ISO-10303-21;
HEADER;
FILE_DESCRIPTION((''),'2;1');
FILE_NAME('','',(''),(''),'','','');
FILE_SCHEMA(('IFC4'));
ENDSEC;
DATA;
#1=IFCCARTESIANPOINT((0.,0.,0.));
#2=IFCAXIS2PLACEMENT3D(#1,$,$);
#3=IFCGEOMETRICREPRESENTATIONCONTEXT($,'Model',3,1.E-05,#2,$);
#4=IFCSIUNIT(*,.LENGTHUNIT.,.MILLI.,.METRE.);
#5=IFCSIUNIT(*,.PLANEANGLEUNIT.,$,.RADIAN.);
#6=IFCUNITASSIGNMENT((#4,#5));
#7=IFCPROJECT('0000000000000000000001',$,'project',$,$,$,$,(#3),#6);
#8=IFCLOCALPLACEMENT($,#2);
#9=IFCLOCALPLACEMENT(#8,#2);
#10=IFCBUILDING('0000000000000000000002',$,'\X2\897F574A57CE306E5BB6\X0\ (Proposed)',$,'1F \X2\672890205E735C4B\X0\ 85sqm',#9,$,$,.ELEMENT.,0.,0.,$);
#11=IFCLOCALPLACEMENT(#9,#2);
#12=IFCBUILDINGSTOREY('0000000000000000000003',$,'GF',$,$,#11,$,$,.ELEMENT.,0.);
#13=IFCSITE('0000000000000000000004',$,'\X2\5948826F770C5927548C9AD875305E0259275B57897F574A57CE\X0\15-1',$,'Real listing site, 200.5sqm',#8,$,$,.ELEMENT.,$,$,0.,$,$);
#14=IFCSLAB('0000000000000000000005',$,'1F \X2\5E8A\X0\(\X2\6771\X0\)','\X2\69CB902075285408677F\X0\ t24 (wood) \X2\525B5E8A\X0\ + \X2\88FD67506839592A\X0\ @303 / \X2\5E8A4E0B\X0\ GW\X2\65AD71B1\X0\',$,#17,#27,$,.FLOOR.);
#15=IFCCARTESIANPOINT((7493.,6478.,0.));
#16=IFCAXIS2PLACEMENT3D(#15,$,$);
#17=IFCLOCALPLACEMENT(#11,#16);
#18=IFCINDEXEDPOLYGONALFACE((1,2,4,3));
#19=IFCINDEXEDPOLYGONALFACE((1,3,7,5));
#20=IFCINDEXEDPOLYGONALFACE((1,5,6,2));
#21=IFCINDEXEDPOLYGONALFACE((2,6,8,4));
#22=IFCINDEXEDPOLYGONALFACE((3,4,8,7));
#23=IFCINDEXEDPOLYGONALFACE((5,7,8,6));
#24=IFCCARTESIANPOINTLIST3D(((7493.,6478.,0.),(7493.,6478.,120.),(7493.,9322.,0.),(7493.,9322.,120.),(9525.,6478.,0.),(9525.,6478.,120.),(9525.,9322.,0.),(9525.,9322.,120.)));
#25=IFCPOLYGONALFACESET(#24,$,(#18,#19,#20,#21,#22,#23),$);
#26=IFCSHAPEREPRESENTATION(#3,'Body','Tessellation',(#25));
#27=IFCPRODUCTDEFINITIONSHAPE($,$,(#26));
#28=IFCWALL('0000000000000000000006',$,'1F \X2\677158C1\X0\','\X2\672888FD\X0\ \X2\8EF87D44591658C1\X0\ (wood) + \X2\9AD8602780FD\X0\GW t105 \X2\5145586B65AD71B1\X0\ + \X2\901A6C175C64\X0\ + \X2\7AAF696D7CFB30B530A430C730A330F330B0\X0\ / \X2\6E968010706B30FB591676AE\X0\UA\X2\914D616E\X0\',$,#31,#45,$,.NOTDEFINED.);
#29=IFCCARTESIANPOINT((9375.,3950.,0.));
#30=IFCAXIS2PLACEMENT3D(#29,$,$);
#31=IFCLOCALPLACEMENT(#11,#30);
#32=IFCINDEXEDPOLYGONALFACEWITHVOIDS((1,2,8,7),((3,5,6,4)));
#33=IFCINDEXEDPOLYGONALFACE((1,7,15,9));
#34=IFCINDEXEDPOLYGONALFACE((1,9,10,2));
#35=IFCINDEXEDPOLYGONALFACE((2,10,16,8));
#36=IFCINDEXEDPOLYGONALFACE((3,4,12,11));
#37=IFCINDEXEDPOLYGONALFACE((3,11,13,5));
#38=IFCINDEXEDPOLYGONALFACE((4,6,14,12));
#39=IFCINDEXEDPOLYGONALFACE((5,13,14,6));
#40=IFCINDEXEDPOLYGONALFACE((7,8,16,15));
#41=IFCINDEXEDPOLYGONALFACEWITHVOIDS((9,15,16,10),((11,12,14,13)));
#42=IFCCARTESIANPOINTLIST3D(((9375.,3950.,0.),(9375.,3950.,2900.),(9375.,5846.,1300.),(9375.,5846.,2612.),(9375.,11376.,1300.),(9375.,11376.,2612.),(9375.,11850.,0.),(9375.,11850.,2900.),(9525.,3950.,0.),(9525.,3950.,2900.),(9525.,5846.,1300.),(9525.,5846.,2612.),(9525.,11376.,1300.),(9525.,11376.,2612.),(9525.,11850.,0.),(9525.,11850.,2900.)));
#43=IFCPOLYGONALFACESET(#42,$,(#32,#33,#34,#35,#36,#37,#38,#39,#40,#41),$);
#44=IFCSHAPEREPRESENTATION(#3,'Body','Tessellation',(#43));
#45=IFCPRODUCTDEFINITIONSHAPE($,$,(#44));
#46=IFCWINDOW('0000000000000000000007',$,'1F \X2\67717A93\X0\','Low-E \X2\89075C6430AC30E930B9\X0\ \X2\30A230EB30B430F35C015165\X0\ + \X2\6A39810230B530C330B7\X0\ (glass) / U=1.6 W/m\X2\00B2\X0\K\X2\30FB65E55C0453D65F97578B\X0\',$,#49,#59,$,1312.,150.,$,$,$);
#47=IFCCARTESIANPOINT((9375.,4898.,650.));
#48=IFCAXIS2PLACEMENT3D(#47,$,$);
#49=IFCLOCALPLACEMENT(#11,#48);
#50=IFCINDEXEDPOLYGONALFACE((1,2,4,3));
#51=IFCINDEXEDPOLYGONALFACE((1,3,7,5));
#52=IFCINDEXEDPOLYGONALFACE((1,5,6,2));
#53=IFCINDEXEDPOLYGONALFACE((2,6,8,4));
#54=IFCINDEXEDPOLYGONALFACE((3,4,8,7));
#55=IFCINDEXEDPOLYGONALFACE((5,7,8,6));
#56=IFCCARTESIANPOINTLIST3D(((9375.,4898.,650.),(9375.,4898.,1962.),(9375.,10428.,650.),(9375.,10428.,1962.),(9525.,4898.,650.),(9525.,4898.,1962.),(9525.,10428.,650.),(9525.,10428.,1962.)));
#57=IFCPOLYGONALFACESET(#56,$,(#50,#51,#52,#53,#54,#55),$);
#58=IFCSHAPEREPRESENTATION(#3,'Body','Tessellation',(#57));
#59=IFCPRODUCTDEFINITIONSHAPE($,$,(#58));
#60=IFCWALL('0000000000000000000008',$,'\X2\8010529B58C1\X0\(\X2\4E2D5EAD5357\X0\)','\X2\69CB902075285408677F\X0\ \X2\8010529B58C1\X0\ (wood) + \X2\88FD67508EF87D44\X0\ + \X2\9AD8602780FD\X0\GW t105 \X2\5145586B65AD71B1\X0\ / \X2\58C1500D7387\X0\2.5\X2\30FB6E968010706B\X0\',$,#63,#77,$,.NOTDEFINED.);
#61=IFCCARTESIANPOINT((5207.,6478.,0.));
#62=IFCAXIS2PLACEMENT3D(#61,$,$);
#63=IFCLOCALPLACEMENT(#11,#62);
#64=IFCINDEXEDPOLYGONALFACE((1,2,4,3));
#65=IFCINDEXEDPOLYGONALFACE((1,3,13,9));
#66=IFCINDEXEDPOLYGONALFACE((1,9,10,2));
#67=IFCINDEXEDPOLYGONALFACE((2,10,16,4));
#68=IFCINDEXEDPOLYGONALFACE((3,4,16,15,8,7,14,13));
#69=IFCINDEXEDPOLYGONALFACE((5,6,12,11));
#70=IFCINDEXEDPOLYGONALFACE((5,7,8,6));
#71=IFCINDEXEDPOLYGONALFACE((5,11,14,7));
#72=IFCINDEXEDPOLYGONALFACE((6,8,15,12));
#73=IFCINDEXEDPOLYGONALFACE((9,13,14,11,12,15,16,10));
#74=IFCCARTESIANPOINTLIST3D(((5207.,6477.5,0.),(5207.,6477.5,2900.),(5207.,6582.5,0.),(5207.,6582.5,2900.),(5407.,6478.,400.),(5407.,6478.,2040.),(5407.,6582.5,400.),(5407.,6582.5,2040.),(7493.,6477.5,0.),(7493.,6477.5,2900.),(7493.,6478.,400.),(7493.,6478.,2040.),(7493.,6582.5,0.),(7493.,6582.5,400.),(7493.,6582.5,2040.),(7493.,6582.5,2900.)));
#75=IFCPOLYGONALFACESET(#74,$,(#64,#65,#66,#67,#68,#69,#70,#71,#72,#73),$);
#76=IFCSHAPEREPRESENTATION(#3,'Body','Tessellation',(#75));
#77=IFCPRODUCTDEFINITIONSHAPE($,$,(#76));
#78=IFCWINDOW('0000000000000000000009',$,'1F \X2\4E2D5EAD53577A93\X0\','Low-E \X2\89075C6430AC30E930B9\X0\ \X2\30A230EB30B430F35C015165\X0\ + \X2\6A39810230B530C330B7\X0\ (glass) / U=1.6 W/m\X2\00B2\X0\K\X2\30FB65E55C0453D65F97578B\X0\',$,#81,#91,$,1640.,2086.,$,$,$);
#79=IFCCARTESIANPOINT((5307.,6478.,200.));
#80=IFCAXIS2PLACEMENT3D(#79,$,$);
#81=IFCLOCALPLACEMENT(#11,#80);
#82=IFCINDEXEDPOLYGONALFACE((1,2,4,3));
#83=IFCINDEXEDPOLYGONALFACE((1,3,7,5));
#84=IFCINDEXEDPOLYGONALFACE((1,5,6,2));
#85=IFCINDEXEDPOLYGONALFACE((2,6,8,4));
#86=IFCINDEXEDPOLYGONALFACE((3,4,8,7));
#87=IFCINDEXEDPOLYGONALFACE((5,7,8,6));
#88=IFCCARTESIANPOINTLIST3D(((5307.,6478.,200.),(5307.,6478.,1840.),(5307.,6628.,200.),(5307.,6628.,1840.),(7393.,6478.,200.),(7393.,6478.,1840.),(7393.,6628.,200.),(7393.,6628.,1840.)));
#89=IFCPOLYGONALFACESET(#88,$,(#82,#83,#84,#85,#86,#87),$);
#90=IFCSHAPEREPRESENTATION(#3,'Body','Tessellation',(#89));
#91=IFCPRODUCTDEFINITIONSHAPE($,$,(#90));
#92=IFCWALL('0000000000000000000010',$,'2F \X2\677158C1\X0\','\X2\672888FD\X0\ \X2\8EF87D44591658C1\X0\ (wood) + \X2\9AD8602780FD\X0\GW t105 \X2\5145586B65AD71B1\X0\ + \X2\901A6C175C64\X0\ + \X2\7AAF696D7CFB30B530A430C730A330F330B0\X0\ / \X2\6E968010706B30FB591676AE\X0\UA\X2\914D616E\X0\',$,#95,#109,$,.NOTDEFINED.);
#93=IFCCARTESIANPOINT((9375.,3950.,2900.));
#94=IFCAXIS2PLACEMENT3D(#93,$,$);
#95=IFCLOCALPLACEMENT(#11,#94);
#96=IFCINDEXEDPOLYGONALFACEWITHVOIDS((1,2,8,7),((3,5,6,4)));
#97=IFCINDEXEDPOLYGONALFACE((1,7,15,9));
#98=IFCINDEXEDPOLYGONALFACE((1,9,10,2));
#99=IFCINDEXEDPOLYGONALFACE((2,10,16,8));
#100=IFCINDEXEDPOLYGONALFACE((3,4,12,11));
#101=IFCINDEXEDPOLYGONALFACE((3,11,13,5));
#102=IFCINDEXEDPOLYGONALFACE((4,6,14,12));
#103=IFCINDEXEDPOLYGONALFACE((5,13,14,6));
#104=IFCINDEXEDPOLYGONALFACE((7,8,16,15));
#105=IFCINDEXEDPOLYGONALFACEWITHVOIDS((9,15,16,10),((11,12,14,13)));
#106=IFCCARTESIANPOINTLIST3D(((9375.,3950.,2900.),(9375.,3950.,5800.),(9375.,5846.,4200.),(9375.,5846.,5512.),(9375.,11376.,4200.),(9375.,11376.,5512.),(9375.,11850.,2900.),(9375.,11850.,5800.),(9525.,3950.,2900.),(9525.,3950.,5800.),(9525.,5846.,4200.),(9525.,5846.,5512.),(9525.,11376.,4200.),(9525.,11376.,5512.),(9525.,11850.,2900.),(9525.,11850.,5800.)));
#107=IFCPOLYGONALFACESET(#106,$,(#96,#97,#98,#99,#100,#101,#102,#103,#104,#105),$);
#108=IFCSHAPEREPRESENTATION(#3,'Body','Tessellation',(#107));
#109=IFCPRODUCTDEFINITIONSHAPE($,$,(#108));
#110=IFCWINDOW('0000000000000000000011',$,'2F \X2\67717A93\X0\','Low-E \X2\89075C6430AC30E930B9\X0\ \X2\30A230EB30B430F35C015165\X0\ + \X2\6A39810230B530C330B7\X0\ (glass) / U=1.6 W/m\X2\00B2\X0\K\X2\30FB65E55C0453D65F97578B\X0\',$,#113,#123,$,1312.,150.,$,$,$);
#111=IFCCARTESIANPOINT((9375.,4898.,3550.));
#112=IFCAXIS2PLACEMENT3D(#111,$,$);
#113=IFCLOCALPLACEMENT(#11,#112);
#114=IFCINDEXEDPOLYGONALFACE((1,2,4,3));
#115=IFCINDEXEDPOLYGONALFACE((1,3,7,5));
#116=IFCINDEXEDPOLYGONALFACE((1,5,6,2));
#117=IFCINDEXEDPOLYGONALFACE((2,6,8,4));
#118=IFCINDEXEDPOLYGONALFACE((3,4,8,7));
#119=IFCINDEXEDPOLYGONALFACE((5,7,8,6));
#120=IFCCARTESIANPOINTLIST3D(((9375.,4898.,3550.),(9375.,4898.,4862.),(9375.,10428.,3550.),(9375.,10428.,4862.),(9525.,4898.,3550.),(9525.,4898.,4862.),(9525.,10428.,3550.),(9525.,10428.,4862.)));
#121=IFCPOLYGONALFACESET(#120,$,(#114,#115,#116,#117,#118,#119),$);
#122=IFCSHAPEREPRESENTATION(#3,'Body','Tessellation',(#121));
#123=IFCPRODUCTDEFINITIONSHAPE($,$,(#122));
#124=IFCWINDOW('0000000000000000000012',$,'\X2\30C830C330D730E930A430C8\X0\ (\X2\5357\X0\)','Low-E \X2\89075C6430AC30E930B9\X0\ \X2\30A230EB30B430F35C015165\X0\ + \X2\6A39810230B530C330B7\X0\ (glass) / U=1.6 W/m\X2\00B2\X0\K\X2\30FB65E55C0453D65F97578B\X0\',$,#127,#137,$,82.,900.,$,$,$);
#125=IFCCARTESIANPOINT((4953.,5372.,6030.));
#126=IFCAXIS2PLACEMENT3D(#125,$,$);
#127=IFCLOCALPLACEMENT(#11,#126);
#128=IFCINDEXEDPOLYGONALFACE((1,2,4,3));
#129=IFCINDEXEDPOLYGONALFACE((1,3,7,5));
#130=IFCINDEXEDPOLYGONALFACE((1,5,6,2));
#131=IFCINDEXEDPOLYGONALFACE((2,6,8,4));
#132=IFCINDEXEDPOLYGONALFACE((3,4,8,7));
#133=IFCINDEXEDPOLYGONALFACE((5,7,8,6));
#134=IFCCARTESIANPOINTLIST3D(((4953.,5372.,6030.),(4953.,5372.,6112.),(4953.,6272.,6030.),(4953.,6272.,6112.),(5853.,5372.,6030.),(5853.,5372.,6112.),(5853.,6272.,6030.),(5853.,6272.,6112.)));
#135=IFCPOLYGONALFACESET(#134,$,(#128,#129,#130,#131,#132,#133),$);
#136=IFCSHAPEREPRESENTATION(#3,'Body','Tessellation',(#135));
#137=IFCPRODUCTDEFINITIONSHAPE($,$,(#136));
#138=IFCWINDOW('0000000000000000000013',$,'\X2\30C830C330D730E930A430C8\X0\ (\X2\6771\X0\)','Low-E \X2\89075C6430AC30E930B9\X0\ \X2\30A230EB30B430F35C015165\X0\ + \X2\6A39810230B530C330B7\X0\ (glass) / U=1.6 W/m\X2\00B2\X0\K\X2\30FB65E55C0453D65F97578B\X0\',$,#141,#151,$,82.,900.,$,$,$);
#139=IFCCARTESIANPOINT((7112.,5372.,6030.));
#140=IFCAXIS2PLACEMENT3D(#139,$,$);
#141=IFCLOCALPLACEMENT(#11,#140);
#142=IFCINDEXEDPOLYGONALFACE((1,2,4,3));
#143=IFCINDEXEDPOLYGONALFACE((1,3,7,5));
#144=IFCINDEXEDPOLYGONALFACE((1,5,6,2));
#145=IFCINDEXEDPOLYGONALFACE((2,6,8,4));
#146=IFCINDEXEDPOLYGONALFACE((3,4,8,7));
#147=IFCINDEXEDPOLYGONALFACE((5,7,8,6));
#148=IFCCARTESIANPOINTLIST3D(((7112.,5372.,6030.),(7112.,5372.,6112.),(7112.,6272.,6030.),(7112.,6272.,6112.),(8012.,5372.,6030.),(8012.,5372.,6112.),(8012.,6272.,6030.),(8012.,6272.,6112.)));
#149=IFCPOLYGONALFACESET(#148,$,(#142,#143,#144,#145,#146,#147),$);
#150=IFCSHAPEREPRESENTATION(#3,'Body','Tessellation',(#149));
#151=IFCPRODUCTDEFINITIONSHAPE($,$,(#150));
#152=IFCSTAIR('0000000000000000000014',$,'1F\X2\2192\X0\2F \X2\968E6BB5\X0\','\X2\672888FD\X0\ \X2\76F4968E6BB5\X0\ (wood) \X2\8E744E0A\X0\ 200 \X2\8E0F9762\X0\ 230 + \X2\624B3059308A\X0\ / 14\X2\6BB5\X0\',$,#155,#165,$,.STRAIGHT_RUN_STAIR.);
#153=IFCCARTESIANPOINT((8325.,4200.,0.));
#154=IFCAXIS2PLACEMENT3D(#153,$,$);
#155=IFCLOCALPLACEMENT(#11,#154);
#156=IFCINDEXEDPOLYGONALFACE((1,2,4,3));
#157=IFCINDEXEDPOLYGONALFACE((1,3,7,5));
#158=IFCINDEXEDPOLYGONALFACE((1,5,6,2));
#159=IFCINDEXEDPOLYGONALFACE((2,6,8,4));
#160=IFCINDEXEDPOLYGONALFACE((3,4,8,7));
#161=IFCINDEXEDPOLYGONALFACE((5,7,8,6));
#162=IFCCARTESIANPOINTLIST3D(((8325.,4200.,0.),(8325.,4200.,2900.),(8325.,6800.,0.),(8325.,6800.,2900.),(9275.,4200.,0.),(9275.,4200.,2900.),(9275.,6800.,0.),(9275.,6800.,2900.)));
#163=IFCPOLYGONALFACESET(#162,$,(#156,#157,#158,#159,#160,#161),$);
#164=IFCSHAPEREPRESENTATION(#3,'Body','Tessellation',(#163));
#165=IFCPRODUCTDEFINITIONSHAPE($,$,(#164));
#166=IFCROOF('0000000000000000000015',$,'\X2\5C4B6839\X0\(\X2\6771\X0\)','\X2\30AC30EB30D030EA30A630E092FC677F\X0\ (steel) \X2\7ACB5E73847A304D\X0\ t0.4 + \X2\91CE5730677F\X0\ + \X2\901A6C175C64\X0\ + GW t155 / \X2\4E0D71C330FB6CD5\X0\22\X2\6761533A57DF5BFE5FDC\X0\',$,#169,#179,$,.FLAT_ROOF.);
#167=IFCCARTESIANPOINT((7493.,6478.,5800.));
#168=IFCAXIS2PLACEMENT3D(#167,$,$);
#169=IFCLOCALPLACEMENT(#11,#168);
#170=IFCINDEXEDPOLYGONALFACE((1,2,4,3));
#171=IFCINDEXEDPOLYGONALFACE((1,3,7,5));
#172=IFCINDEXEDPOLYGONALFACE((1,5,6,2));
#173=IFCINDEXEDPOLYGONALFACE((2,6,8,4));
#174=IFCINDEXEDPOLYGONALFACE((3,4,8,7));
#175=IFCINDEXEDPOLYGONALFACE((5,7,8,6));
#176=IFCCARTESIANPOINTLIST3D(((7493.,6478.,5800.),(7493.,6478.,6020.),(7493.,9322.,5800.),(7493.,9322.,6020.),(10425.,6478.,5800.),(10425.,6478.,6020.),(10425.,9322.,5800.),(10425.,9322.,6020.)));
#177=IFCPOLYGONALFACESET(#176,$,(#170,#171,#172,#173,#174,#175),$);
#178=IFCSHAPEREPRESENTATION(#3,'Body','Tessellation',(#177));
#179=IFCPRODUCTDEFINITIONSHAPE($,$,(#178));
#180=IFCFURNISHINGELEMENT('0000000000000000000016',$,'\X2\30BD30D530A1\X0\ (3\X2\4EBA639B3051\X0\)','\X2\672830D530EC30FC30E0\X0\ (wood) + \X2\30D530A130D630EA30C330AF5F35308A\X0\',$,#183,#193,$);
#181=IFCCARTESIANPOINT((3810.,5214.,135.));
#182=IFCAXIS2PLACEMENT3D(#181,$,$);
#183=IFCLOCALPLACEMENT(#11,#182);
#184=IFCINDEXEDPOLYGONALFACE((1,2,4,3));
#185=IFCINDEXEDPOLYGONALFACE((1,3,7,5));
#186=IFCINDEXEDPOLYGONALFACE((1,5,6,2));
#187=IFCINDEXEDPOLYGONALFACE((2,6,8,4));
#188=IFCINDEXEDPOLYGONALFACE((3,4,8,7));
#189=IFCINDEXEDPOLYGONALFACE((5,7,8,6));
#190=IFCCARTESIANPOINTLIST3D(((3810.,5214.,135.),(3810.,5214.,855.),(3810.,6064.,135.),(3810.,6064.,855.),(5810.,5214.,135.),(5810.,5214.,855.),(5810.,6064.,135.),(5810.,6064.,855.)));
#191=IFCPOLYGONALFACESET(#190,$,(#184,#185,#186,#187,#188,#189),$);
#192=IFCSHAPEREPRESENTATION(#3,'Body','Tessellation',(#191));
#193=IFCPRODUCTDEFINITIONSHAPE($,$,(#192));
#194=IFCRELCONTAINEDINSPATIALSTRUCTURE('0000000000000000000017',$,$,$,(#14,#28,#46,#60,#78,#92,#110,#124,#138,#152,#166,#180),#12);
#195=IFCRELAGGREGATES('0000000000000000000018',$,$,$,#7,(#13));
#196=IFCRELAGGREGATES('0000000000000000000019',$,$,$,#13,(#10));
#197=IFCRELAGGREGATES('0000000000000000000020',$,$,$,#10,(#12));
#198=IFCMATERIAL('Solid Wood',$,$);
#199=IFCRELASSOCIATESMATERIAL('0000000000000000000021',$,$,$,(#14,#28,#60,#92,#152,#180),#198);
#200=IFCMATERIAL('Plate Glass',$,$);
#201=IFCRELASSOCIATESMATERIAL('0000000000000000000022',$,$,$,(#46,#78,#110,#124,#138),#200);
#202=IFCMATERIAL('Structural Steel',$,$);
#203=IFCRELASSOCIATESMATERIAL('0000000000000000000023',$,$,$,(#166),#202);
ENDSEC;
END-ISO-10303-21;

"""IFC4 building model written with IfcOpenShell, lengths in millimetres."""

from ifc_helpers import new_model, si_unit, frame, frame_2d, origin, place, context, project, spatial, rectangle, extrude, material, element, fill, save


model = new_model("IFC4")

# Units and contexts
model_context = context("Model", 3, precision=1e-05, world=origin())
ifc_project = project(units=[si_unit("LENGTHUNIT", "METRE", prefix="MILLI"), si_unit("PLANEANGLEUNIT", "RADIAN")], contexts=[model_context])

# Site, building, storey
site_placement = place(None, origin())
site = spatial("IfcSite", under=ifc_project, at=site_placement, Name="奈良県大和高田市大字西坊城15-1", ObjectType="Real listing site, 200.5sqm", CompositionType="ELEMENT", RefElevation=0.0)
building_placement = place(site_placement, origin())
building = spatial("IfcBuilding", under=site, at=building_placement, Name="西坊城の家 (Proposed)", ObjectType="1F 木造平屋 85sqm", CompositionType="ELEMENT", ElevationOfRefHeight=0.0, ElevationOfTerrain=0.0)
storey_placement = place(building_placement, origin())
storey = spatial("IfcBuildingStorey", under=building, at=storey_placement, Name="GF", CompositionType="ELEMENT", Elevation=0.0)

# Slab
ifc_material_1 = material(Name="Solid Wood")
slab_placement = place(storey_placement, frame((7493.0, 6478.0, 0.0)))
element("IfcSlab", 1, at=slab_placement, inside=storey, material=ifc_material_1, Name="1F 床(東)", Description="構造用合板 t24 (wood) 剛床 + 製材根太 @303 / 床下 GW断熱", PredefinedType="FLOOR", context=model_context, shape_type="SweptSolid", body=[
    extrude(rectangle(XDim=2032.0, YDim=2844.0, at=frame_2d((1016.0, 1422.0))), frame((7493.0, 6478.0, 0.0)), (0.0, 0.0, 1.0), 120.0),
])

# Walls, openings, windows
wall_1_placement = place(storey_placement, frame((9375.0, 3950.0, 0.0)))
wall_1 = element("IfcWall", 2, at=wall_1_placement, inside=storey, material=ifc_material_1, Name="1F 東壁", Description="木製 軸組外壁 (wood) + 高性能GW t105 充填断熱 + 通気層 + 窯業系サイディング / 準耐火・外皮UA配慮", PredefinedType="NOTDEFINED", context=model_context, shape_type="SweptSolid", body=[
    extrude(rectangle(XDim=150.0, YDim=7900.0, at=frame_2d((75.0, 3950.0))), frame((9375.0, 3950.0, 0.0)), (0.0, 0.0, 1.0), 2900.0),
])
opening_1_placement = place(storey_placement, frame((9375.0, 4898.0, 650.0)))
opening_1 = element("IfcOpeningElement", 3, at=opening_1_placement, cuts=wall_1, PredefinedType="NOTDEFINED", context=model_context, shape_type="SweptSolid", body=[
    extrude(rectangle(XDim=150.0, YDim=5530.0, at=frame_2d((75.0, 2765.0))), frame((9375.0, 4898.0, 650.0)), (0.0, 0.0, 1.0), 1312.0),
])
ifc_material_2 = material(Name="Plate Glass")
window_1_placement = place(storey_placement, frame((9375.0, 4898.0, 650.0)))
window_1 = element("IfcWindow", 4, at=window_1_placement, inside=storey, material=ifc_material_2, Name="1F 東窓", Description="Low-E 複層ガラス アルゴン封入 + 樹脂サッシ (glass) / U=1.6 W/m²K・日射取得型", OverallHeight=1312.0, OverallWidth=150.0, context=model_context, shape_type="SweptSolid", body=[
    extrude(rectangle(XDim=150.0, YDim=5530.0, at=frame_2d((75.0, 2765.0))), frame((9375.0, 4898.0, 650.0)), (0.0, 0.0, 1.0), 1312.0),
])
fill(opening_1, window_1)
wall_2_placement = place(storey_placement, frame((5207.0, 6478.0, 0.0)))
wall_2 = element("IfcWall", 5, at=wall_2_placement, inside=storey, material=ifc_material_1, Name="耐力壁(中庭南)", Description="構造用合板 耐力壁 (wood) + 製材軸組 + 高性能GW t105 充填断熱 / 壁倍率2.5・準耐火", PredefinedType="NOTDEFINED", context=model_context, shape_type="SweptSolid", body=[
    extrude(rectangle(XDim=2286.0, YDim=105.0, at=frame_2d((1143.0, 52.0))), frame((5207.0, 6478.0, 0.0)), (0.0, 0.0, 1.0), 2900.0),
])
opening_2_placement = place(storey_placement, frame((5307.0, 6478.0, 200.0)))
opening_2 = element("IfcOpeningElement", 6, at=opening_2_placement, cuts=wall_2, PredefinedType="NOTDEFINED", context=model_context, shape_type="SweptSolid", body=[
    extrude(rectangle(XDim=2086.0, YDim=150.0, at=frame_2d((1043.0, 75.0))), frame((5307.0, 6478.0, 200.0)), (0.0, 0.0, 1.0), 1640.0),
])
window_2_placement = place(storey_placement, frame((5307.0, 6478.0, 200.0)))
window_2 = element("IfcWindow", 7, at=window_2_placement, inside=storey, material=ifc_material_2, Name="1F 中庭南窓", Description="Low-E 複層ガラス アルゴン封入 + 樹脂サッシ (glass) / U=1.6 W/m²K・日射取得型", OverallHeight=1640.0, OverallWidth=2086.0, context=model_context, shape_type="SweptSolid", body=[
    extrude(rectangle(XDim=2086.0, YDim=150.0, at=frame_2d((1043.0, 75.0))), frame((5307.0, 6478.0, 200.0)), (0.0, 0.0, 1.0), 1640.0),
])
fill(opening_2, window_2)

# Wall, opening, window
wall_3_placement = place(storey_placement, frame((9375.0, 3950.0, 2900.0)))
wall_3 = element("IfcWall", 8, at=wall_3_placement, inside=storey, material=ifc_material_1, Name="2F 東壁", Description="木製 軸組外壁 (wood) + 高性能GW t105 充填断熱 + 通気層 + 窯業系サイディング / 準耐火・外皮UA配慮", PredefinedType="NOTDEFINED", context=model_context, shape_type="SweptSolid", body=[
    extrude(rectangle(XDim=150.0, YDim=7900.0, at=frame_2d((75.0, 3950.0))), frame((9375.0, 3950.0, 2900.0)), (0.0, 0.0, 1.0), 2900.0),
])
opening_3_placement = place(storey_placement, frame((9375.0, 4898.0, 3550.0)))
opening_3 = element("IfcOpeningElement", 9, at=opening_3_placement, cuts=wall_3, PredefinedType="NOTDEFINED", context=model_context, shape_type="SweptSolid", body=[
    extrude(rectangle(XDim=150.0, YDim=5530.0, at=frame_2d((75.0, 2765.0))), frame((9375.0, 4898.0, 3550.0)), (0.0, 0.0, 1.0), 1312.0),
])
window_3_placement = place(storey_placement, frame((9375.0, 4898.0, 3550.0)))
window_3 = element("IfcWindow", 10, at=window_3_placement, inside=storey, material=ifc_material_2, Name="2F 東窓", Description="Low-E 複層ガラス アルゴン封入 + 樹脂サッシ (glass) / U=1.6 W/m²K・日射取得型", OverallHeight=1312.0, OverallWidth=150.0, context=model_context, shape_type="SweptSolid", body=[
    extrude(rectangle(XDim=150.0, YDim=5530.0, at=frame_2d((75.0, 2765.0))), frame((9375.0, 4898.0, 3550.0)), (0.0, 0.0, 1.0), 1312.0),
])
fill(opening_3, window_3)

# Windows
window_4_placement = place(storey_placement, frame((4953.0, 5372.0, 6030.0)))
element("IfcWindow", 11, at=window_4_placement, inside=storey, material=ifc_material_2, Name="トップライト (南)", Description="Low-E 複層ガラス アルゴン封入 + 樹脂サッシ (glass) / U=1.6 W/m²K・日射取得型", OverallHeight=82.0, OverallWidth=900.0, context=model_context, shape_type="SweptSolid", body=[
    extrude(rectangle(XDim=900.0, YDim=900.0, at=frame_2d((450.0, 450.0))), frame((4953.0, 5372.0, 6030.0)), (0.0, 0.0, 1.0), 82.0),
])
window_5_placement = place(storey_placement, frame((7112.0, 5372.0, 6030.0)))
element("IfcWindow", 12, at=window_5_placement, inside=storey, material=ifc_material_2, Name="トップライト (東)", Description="Low-E 複層ガラス アルゴン封入 + 樹脂サッシ (glass) / U=1.6 W/m²K・日射取得型", OverallHeight=82.0, OverallWidth=900.0, context=model_context, shape_type="SweptSolid", body=[
    extrude(rectangle(XDim=900.0, YDim=900.0, at=frame_2d((450.0, 450.0))), frame((7112.0, 5372.0, 6030.0)), (0.0, 0.0, 1.0), 82.0),
])

# Stair
stair_placement = place(storey_placement, frame((8325.0, 4200.0, 0.0)))
element("IfcStair", 13, at=stair_placement, inside=storey, material=ifc_material_1, Name="1F→2F 階段", Description="木製 直階段 (wood) 蹴上 200 踏面 230 + 手すり / 14段", PredefinedType="STRAIGHT_RUN_STAIR", context=model_context, shape_type="SweptSolid", body=[
    extrude(rectangle(XDim=950.0, YDim=2600.0, at=frame_2d((475.0, 1300.0))), frame((8325.0, 4200.0, 0.0)), (0.0, 0.0, 1.0), 2900.0),
])

# Roof
ifc_material_3 = material(Name="Structural Steel")
roof_placement = place(storey_placement, frame((7493.0, 6478.0, 5800.0)))
element("IfcRoof", 14, at=roof_placement, inside=storey, material=ifc_material_3, Name="屋根(東)", Description="ガルバリウム鋼板 (steel) 立平葺き t0.4 + 野地板 + 通気層 + GW t155 / 不燃・法22条区域対応", PredefinedType="FLAT_ROOF", context=model_context, shape_type="SweptSolid", body=[
    extrude(rectangle(XDim=2932.0, YDim=2844.0, at=frame_2d((1466.0, 1422.0))), frame((7493.0, 6478.0, 5800.0)), (0.0, 0.0, 1.0), 220.0),
])

# Furnishing element
furnishing_1_placement = place(storey_placement, frame((3810.0, 5214.0, 135.0)))
element("IfcFurnishingElement", 15, at=furnishing_1_placement, inside=storey, material=ifc_material_1, Name="ソファ (3人掛け)", Description="木フレーム (wood) + ファブリック張り", context=model_context, shape_type="SweptSolid", body=[
    extrude(rectangle(XDim=2000.0, YDim=850.0, at=frame_2d((1000.0, 425.0))), frame((3810.0, 5214.0, 135.0)), (0.0, 0.0, 1.0), 720.0),
])

save(model, "model.ifc")
